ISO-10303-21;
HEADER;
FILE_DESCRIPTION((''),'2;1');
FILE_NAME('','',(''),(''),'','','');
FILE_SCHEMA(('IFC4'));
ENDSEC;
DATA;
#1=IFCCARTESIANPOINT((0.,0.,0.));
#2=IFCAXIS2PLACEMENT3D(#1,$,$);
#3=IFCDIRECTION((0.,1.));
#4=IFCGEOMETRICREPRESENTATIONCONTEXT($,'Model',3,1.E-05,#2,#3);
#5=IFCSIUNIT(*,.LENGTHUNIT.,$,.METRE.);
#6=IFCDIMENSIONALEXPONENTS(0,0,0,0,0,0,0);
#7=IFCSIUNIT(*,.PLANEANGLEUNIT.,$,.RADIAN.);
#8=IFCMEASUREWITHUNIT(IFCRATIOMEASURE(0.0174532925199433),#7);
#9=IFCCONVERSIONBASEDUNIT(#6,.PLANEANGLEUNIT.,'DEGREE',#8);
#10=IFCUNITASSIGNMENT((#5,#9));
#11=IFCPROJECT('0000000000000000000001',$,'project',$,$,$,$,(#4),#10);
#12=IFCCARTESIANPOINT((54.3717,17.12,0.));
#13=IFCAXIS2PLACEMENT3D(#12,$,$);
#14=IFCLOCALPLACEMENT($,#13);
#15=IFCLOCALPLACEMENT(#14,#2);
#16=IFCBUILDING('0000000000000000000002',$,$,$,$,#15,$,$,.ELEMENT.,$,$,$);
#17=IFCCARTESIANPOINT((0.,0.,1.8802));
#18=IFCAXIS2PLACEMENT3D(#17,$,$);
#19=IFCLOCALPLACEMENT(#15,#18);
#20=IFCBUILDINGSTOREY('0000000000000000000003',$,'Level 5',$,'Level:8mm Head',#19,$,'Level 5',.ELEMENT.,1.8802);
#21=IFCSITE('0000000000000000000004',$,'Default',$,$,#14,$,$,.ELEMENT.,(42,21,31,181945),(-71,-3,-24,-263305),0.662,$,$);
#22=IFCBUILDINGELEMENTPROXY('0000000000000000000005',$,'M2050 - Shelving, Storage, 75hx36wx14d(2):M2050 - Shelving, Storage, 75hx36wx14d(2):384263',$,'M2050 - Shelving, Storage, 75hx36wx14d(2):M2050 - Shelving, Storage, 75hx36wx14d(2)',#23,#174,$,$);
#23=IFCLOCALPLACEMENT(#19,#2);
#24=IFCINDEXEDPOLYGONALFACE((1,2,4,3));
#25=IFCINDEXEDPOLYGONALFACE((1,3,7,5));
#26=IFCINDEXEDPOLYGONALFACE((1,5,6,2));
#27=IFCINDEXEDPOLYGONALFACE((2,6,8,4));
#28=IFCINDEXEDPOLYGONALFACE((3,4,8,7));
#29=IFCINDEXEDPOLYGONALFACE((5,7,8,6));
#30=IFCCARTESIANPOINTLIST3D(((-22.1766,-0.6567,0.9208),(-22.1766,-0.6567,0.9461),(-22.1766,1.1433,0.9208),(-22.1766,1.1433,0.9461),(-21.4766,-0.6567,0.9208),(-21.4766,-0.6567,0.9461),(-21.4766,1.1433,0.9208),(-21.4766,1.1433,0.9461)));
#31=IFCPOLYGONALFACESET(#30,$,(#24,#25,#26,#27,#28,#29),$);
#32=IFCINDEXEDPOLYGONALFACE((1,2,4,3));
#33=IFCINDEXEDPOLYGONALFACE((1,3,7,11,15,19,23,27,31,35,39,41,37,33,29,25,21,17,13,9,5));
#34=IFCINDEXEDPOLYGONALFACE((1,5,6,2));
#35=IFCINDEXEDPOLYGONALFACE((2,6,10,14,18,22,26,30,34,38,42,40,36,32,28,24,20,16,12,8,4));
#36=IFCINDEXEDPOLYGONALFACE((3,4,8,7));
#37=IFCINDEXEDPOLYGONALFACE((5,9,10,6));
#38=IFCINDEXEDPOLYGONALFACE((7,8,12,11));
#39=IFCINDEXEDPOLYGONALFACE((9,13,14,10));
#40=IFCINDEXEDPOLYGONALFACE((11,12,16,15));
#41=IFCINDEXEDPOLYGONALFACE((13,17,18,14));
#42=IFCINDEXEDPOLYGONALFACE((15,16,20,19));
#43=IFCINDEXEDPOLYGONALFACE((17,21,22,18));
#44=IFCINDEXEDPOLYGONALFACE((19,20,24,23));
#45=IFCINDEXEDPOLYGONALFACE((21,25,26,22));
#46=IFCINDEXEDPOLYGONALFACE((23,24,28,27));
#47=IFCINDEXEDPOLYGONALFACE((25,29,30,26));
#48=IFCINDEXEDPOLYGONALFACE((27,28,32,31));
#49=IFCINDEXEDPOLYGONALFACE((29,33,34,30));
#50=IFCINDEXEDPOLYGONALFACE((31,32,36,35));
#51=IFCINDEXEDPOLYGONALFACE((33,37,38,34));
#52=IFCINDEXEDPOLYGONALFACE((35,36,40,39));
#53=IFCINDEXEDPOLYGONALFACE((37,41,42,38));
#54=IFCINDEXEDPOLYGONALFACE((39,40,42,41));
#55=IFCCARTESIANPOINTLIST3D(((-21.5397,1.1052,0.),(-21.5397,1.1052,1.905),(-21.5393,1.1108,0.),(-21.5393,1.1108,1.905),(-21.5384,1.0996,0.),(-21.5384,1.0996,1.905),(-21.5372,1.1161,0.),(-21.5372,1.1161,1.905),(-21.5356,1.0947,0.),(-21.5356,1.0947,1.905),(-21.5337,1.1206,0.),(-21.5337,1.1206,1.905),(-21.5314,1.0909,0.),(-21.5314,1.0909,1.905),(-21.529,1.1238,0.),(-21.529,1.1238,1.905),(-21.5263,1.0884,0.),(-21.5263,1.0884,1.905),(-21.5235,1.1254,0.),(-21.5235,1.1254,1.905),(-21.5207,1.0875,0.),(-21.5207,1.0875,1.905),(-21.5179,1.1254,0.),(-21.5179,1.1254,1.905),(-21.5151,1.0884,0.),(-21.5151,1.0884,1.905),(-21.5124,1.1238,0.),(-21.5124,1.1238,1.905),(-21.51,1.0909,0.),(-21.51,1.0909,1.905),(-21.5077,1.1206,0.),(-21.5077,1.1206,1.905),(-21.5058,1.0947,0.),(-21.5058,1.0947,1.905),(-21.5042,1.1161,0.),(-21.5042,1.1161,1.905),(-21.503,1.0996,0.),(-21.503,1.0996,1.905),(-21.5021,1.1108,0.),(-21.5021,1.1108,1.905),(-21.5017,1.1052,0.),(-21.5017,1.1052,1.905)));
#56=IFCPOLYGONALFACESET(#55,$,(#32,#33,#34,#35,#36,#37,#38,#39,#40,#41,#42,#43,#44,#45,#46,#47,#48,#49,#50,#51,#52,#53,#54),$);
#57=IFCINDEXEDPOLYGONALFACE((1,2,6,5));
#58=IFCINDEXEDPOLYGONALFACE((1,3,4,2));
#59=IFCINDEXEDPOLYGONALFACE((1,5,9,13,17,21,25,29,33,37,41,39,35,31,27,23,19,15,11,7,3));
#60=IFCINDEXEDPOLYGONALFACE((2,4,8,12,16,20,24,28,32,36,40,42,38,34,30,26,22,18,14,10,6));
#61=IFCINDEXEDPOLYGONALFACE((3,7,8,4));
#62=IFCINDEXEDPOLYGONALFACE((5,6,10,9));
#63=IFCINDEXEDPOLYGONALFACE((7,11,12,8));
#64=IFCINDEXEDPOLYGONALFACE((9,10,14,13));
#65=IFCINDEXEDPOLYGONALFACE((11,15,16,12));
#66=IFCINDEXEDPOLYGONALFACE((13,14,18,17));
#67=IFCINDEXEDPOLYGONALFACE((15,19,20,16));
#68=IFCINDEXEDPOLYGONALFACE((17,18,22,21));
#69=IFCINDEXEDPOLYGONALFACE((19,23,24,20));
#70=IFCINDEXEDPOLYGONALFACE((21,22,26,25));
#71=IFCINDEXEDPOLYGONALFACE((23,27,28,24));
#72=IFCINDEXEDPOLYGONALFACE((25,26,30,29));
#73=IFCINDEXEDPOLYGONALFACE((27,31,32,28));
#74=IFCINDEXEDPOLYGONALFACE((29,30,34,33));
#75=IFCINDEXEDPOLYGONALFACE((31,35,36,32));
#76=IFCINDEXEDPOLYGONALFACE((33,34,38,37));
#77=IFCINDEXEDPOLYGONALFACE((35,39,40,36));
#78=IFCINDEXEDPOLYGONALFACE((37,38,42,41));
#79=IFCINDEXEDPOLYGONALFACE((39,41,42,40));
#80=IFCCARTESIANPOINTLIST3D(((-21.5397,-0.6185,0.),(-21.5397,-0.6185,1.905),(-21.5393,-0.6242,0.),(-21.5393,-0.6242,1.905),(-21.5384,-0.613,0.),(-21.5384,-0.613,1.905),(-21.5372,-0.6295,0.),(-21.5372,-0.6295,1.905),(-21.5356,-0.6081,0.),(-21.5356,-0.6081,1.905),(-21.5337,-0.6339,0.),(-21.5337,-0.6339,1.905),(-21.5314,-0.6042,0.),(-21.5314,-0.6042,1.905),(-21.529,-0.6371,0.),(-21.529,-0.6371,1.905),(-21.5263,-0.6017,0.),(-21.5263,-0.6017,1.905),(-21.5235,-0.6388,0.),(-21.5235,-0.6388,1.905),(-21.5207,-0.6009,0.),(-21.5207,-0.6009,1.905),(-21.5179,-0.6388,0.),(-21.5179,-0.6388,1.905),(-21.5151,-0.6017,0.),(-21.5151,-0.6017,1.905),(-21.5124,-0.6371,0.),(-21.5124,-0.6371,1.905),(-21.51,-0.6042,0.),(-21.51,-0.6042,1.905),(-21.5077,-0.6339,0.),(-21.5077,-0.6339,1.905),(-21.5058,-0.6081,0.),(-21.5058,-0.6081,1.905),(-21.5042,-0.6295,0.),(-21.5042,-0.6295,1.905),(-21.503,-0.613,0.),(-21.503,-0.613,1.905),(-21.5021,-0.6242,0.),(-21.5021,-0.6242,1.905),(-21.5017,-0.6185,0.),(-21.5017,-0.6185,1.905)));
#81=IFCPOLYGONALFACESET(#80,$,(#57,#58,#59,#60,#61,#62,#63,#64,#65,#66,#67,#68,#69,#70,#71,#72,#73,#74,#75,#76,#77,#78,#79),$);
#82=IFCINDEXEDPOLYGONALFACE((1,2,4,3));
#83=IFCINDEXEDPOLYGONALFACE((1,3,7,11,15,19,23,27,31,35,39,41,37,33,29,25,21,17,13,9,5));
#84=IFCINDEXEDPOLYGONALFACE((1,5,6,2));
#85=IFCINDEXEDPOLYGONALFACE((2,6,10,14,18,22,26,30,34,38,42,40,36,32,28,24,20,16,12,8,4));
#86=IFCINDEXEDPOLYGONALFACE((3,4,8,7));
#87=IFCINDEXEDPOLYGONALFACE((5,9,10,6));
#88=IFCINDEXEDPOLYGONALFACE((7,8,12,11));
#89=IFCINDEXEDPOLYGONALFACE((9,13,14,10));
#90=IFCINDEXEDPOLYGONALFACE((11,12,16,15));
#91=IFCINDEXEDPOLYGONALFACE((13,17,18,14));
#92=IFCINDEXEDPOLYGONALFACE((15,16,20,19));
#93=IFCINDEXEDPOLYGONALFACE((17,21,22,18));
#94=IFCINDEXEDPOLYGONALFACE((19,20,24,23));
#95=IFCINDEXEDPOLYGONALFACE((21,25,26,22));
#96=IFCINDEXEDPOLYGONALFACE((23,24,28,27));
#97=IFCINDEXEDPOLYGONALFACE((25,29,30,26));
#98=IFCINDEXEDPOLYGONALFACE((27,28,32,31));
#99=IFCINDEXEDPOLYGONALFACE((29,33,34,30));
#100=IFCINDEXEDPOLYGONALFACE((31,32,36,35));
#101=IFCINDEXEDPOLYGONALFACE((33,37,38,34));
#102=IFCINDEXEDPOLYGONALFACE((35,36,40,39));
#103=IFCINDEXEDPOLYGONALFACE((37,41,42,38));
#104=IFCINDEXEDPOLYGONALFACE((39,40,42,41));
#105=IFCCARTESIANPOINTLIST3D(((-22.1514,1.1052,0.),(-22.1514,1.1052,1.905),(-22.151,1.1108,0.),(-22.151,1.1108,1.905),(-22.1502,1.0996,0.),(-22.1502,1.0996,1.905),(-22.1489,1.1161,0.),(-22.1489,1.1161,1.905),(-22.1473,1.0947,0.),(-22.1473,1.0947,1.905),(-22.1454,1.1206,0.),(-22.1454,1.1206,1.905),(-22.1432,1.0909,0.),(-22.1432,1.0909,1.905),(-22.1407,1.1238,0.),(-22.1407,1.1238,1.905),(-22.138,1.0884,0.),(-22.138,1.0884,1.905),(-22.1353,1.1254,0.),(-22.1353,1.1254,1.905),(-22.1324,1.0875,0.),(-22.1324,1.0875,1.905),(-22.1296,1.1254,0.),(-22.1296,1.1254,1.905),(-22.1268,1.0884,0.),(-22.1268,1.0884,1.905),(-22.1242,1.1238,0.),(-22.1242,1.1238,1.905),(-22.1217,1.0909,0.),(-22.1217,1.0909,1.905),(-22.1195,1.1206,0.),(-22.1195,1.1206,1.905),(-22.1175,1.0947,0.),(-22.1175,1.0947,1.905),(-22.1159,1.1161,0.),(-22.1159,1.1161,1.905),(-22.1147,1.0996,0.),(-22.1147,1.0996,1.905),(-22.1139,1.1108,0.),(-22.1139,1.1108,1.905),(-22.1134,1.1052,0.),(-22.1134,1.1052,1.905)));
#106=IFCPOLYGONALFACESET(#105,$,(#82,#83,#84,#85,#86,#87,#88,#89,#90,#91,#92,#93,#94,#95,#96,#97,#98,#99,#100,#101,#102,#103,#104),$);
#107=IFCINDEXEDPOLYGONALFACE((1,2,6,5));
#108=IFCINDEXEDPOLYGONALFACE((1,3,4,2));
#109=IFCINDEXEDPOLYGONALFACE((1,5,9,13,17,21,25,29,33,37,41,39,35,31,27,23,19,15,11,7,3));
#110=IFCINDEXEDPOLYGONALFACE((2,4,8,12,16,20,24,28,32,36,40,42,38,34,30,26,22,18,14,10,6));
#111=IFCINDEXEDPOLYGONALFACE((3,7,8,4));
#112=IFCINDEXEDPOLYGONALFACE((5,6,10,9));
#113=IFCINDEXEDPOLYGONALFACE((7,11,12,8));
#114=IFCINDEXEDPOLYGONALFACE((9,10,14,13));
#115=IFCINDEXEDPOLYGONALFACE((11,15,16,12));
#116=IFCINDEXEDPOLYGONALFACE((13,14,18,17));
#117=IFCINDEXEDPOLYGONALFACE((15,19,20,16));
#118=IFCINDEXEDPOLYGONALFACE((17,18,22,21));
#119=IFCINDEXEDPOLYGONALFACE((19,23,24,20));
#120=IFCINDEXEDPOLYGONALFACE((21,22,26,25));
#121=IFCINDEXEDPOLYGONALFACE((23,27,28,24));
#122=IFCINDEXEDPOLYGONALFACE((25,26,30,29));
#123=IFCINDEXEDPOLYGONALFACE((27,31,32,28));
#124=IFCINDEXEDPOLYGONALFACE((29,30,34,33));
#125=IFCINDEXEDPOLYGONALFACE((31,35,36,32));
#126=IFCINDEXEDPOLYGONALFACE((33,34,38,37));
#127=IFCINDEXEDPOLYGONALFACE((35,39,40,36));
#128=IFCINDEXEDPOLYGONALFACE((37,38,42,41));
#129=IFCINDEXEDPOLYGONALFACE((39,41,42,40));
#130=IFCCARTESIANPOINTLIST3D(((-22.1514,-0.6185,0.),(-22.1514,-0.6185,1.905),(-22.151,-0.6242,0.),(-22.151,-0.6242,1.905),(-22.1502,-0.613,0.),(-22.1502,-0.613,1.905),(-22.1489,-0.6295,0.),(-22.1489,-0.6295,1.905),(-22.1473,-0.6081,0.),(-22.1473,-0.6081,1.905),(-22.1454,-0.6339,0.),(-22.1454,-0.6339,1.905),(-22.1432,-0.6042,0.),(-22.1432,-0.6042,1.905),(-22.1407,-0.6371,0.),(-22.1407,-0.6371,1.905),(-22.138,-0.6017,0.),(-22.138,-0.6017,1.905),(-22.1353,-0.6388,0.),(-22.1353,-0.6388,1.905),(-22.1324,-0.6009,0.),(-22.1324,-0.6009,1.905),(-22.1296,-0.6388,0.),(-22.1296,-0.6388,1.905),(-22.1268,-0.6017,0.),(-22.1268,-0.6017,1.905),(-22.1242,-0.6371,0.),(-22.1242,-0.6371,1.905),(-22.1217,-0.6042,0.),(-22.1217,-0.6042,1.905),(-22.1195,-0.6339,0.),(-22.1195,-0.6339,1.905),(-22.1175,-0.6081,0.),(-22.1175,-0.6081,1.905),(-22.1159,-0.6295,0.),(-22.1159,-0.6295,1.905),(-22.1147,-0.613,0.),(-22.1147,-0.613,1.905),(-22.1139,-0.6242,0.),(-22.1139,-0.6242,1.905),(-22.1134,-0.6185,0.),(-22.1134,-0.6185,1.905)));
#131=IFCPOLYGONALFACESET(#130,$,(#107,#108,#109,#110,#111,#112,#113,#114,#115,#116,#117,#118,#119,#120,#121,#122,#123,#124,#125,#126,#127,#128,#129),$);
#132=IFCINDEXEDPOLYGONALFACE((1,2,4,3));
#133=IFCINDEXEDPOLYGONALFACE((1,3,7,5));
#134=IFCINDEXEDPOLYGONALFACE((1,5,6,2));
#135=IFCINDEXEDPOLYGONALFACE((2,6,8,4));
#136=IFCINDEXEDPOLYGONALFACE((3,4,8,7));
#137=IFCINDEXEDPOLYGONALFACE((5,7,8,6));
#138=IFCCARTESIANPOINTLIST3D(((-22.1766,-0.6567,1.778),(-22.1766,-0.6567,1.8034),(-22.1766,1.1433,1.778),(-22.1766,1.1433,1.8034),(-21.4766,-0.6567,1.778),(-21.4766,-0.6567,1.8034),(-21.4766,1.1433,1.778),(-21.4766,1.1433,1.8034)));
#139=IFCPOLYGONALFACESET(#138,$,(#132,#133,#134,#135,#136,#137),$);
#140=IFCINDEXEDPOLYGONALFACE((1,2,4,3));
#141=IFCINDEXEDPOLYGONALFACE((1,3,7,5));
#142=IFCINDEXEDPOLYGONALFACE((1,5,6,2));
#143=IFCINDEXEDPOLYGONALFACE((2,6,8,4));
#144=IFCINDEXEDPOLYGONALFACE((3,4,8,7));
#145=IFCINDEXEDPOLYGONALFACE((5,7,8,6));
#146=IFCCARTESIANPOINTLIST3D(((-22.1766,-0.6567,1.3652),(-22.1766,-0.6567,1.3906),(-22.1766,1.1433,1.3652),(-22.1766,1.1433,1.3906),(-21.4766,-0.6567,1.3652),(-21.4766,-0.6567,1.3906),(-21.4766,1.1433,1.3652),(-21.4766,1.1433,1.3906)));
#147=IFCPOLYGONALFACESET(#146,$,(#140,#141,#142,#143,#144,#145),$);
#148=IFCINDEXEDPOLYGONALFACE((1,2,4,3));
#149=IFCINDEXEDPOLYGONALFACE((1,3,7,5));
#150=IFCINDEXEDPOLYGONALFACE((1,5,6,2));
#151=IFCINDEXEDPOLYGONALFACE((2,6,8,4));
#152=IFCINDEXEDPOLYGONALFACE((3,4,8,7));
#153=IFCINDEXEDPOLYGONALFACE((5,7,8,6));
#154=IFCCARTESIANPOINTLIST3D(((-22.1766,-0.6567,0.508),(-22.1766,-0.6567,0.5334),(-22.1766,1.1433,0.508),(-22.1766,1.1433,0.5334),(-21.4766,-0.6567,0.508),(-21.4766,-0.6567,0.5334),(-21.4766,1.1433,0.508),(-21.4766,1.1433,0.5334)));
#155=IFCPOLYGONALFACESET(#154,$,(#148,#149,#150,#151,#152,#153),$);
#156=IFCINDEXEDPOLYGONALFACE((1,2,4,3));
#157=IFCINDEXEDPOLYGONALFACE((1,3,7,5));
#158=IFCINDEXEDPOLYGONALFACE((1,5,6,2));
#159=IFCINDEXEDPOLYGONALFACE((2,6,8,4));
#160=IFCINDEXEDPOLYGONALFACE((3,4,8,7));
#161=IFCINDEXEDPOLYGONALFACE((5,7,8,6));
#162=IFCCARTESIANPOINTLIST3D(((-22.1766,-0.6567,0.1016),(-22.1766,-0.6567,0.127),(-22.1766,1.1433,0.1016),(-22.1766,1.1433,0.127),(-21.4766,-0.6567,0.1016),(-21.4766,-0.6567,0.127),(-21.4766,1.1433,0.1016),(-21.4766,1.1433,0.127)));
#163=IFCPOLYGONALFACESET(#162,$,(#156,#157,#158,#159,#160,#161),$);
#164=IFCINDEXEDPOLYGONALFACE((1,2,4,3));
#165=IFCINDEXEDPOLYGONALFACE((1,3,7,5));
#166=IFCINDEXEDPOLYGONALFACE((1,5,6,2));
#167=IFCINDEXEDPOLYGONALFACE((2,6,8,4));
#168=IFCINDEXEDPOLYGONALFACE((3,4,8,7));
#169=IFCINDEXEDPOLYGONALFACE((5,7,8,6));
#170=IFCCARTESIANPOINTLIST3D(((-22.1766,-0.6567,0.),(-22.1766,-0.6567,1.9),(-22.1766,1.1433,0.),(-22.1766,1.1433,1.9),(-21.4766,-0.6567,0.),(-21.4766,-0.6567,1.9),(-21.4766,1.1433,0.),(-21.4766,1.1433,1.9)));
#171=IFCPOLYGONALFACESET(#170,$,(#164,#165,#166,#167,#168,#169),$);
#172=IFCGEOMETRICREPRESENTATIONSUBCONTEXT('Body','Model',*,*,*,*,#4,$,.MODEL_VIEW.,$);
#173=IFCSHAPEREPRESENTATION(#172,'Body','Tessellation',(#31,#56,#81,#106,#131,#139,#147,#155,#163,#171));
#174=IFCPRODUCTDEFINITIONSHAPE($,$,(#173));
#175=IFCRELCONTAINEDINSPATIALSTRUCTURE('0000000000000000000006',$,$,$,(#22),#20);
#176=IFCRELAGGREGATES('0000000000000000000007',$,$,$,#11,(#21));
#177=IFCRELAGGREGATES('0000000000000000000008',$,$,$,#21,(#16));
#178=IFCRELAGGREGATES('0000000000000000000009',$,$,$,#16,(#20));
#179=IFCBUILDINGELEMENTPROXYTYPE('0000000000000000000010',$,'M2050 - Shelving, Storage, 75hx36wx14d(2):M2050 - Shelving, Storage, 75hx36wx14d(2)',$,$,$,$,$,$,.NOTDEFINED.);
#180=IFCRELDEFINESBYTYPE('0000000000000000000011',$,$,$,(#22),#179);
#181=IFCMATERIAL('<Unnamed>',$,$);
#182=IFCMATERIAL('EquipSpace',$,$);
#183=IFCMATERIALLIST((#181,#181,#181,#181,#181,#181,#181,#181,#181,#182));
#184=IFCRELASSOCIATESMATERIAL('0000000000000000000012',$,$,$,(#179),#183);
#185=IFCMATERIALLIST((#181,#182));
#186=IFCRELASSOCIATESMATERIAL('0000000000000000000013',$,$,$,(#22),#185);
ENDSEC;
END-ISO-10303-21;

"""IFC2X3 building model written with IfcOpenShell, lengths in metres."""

from ifc_helpers import new_model, entity, si_unit, converted_unit, direction, frame, frame_2d, origin, origin_2d_with_axis, place, context, subcontext, project, spatial, rectangle, circle, extrude, source, transform, mapped, material, material_list, type_object, type_shapes, element, save


model = new_model("IFC2X3")

# Units and contexts
model_context = context("Model", 3, precision=1e-05, world=origin(), true_north=direction((0.0, 1.0)))
body_context = subcontext(model_context, "Body", "Model", "MODEL_VIEW")
ifc_project = project(units=[si_unit("LENGTHUNIT", "METRE"), converted_unit("PLANEANGLEUNIT", "DEGREE", entity("IfcRatioMeasure", 0.0174532925199433), si_unit("PLANEANGLEUNIT", "RADIAN"), dimensions=[0, 0, 0, 0, 0, 0, 0])], contexts=[model_context])

# Site, building, storey
site_placement = place(None, frame((54.3717, 17.12, 0.0)))
site = spatial("IfcSite", under=ifc_project, at=site_placement, Name="Default", CompositionType="ELEMENT", RefLatitude=(42, 21, 31, 181945), RefLongitude=(-71, -3, -24, -263305), RefElevation=0.662)
building_placement = place(site_placement, origin())
building = spatial("IfcBuilding", under=site, at=building_placement, CompositionType="ELEMENT")
storey_placement = place(building_placement, frame((0.0, 0.0, 1.8802)))
storey = spatial("IfcBuildingStorey", under=building, at=storey_placement, Name="Level 5", ObjectType="Level:8mm Head", LongName="Level 5", CompositionType="ELEMENT", Elevation=1.8802)

# Building element proxy
ifc_material_1 = material(Name="<Unnamed>")
ifc_material_2 = material(Name="EquipSpace")
ifc_material_list_1 = material_list([ifc_material_1, ifc_material_1, ifc_material_1, ifc_material_1, ifc_material_1, ifc_material_1, ifc_material_1, ifc_material_1, ifc_material_1, ifc_material_2])
building_element_proxy_type = type_object("IfcBuildingElementProxyType", Name="M2050 - Shelving, Storage, 75hx36wx14d(2):M2050 - Shelving, Storage, 75hx36wx14d(2)", PredefinedType="NOTDEFINED", material=ifc_material_list_1)
shared_shape = source(origin(), body_context, "Body", "SweptSolid", [
    extrude(rectangle(XDim=1.8, YDim=0.7, at=origin_2d_with_axis()), frame((0.0, 0.0, 0.9207), z_axis=(0.0, 0.0, 1.0), x_axis=(-1.0, 0.0, 0.0)), (0.0, 0.0, 1.0), 0.0254),
    extrude(circle(Radius=0.0191, at=origin_2d_with_axis()), frame((0.8633, -0.3059, 0.0), z_axis=(0.0, 0.0, 1.0), x_axis=(-1.0, 0.0, 0.0)), (0.0, 0.0, 1.0), 1.905),
    extrude(circle(Radius=0.0191, at=origin_2d_with_axis()), frame((-0.8633, -0.3059, 0.0)), (0.0, 0.0, 1.0), 1.905),
    extrude(circle(Radius=0.0191, at=origin_2d_with_axis()), frame((0.8633, 0.3059, 0.0), z_axis=(0.0, 0.0, 1.0), x_axis=(-1.0, 0.0, 0.0)), (0.0, 0.0, 1.0), 1.905),
    extrude(circle(Radius=0.0191, at=origin_2d_with_axis()), frame((-0.8633, 0.3059, 0.0)), (0.0, 0.0, 1.0), 1.905),
    extrude(rectangle(XDim=1.8, YDim=0.7, at=origin_2d_with_axis()), frame((0.0, 0.0, 1.778), z_axis=(0.0, 0.0, 1.0), x_axis=(-1.0, 0.0, 0.0)), (0.0, 0.0, 1.0), 0.0254),
    extrude(rectangle(XDim=1.8, YDim=0.7, at=origin_2d_with_axis()), frame((0.0, 0.0, 1.3653), z_axis=(0.0, 0.0, 1.0), x_axis=(-1.0, 0.0, 0.0)), (0.0, 0.0, 1.0), 0.0254),
    extrude(rectangle(XDim=1.8, YDim=0.7, at=origin_2d_with_axis()), frame((0.0, 0.0, 0.508), z_axis=(0.0, 0.0, 1.0), x_axis=(-1.0, 0.0, 0.0)), (0.0, 0.0, 1.0), 0.0254),
    extrude(rectangle(XDim=1.8, YDim=0.7, at=origin_2d_with_axis()), frame((0.0, 0.0, 0.1016), z_axis=(0.0, 0.0, 1.0), x_axis=(-1.0, 0.0, 0.0)), (0.0, 0.0, 1.0), 0.0254),
    extrude(rectangle(XDim=0.7, YDim=1.8, at=frame_2d((0.0, 0.18), x_axis=(1.0, 0.0))), frame((-0.18, 0.0, 0.0), z_axis=(0.0, 0.0, 1.0), x_axis=(0.0, -1.0, 0.0)), (0.0, 0.0, 1.0), 1.9),
])
type_shapes(building_element_proxy_type, [shared_shape])
ifc_material_list_2 = material_list([ifc_material_1, ifc_material_2])
proxy_1_placement = place(storey_placement, frame((-21.8266, 0.2433, 0.0), z_axis=(0.0, 0.0, 1.0), x_axis=(0.0, 1.0, 0.0)))
element("IfcBuildingElementProxy", 1, at=proxy_1_placement, inside=storey, type_object=building_element_proxy_type, material=ifc_material_list_2, Name="M2050 - Shelving, Storage, 75hx36wx14d(2):M2050 - Shelving, Storage, 75hx36wx14d(2):384263", ObjectType="M2050 - Shelving, Storage, 75hx36wx14d(2):M2050 - Shelving, Storage, 75hx36wx14d(2)", context=body_context, shape_type="MappedRepresentation", body=[
    mapped(shared_shape, transform((0.0, 0.0, 0.0), scale=1.0)),
])

save(model, "model.ifc")
